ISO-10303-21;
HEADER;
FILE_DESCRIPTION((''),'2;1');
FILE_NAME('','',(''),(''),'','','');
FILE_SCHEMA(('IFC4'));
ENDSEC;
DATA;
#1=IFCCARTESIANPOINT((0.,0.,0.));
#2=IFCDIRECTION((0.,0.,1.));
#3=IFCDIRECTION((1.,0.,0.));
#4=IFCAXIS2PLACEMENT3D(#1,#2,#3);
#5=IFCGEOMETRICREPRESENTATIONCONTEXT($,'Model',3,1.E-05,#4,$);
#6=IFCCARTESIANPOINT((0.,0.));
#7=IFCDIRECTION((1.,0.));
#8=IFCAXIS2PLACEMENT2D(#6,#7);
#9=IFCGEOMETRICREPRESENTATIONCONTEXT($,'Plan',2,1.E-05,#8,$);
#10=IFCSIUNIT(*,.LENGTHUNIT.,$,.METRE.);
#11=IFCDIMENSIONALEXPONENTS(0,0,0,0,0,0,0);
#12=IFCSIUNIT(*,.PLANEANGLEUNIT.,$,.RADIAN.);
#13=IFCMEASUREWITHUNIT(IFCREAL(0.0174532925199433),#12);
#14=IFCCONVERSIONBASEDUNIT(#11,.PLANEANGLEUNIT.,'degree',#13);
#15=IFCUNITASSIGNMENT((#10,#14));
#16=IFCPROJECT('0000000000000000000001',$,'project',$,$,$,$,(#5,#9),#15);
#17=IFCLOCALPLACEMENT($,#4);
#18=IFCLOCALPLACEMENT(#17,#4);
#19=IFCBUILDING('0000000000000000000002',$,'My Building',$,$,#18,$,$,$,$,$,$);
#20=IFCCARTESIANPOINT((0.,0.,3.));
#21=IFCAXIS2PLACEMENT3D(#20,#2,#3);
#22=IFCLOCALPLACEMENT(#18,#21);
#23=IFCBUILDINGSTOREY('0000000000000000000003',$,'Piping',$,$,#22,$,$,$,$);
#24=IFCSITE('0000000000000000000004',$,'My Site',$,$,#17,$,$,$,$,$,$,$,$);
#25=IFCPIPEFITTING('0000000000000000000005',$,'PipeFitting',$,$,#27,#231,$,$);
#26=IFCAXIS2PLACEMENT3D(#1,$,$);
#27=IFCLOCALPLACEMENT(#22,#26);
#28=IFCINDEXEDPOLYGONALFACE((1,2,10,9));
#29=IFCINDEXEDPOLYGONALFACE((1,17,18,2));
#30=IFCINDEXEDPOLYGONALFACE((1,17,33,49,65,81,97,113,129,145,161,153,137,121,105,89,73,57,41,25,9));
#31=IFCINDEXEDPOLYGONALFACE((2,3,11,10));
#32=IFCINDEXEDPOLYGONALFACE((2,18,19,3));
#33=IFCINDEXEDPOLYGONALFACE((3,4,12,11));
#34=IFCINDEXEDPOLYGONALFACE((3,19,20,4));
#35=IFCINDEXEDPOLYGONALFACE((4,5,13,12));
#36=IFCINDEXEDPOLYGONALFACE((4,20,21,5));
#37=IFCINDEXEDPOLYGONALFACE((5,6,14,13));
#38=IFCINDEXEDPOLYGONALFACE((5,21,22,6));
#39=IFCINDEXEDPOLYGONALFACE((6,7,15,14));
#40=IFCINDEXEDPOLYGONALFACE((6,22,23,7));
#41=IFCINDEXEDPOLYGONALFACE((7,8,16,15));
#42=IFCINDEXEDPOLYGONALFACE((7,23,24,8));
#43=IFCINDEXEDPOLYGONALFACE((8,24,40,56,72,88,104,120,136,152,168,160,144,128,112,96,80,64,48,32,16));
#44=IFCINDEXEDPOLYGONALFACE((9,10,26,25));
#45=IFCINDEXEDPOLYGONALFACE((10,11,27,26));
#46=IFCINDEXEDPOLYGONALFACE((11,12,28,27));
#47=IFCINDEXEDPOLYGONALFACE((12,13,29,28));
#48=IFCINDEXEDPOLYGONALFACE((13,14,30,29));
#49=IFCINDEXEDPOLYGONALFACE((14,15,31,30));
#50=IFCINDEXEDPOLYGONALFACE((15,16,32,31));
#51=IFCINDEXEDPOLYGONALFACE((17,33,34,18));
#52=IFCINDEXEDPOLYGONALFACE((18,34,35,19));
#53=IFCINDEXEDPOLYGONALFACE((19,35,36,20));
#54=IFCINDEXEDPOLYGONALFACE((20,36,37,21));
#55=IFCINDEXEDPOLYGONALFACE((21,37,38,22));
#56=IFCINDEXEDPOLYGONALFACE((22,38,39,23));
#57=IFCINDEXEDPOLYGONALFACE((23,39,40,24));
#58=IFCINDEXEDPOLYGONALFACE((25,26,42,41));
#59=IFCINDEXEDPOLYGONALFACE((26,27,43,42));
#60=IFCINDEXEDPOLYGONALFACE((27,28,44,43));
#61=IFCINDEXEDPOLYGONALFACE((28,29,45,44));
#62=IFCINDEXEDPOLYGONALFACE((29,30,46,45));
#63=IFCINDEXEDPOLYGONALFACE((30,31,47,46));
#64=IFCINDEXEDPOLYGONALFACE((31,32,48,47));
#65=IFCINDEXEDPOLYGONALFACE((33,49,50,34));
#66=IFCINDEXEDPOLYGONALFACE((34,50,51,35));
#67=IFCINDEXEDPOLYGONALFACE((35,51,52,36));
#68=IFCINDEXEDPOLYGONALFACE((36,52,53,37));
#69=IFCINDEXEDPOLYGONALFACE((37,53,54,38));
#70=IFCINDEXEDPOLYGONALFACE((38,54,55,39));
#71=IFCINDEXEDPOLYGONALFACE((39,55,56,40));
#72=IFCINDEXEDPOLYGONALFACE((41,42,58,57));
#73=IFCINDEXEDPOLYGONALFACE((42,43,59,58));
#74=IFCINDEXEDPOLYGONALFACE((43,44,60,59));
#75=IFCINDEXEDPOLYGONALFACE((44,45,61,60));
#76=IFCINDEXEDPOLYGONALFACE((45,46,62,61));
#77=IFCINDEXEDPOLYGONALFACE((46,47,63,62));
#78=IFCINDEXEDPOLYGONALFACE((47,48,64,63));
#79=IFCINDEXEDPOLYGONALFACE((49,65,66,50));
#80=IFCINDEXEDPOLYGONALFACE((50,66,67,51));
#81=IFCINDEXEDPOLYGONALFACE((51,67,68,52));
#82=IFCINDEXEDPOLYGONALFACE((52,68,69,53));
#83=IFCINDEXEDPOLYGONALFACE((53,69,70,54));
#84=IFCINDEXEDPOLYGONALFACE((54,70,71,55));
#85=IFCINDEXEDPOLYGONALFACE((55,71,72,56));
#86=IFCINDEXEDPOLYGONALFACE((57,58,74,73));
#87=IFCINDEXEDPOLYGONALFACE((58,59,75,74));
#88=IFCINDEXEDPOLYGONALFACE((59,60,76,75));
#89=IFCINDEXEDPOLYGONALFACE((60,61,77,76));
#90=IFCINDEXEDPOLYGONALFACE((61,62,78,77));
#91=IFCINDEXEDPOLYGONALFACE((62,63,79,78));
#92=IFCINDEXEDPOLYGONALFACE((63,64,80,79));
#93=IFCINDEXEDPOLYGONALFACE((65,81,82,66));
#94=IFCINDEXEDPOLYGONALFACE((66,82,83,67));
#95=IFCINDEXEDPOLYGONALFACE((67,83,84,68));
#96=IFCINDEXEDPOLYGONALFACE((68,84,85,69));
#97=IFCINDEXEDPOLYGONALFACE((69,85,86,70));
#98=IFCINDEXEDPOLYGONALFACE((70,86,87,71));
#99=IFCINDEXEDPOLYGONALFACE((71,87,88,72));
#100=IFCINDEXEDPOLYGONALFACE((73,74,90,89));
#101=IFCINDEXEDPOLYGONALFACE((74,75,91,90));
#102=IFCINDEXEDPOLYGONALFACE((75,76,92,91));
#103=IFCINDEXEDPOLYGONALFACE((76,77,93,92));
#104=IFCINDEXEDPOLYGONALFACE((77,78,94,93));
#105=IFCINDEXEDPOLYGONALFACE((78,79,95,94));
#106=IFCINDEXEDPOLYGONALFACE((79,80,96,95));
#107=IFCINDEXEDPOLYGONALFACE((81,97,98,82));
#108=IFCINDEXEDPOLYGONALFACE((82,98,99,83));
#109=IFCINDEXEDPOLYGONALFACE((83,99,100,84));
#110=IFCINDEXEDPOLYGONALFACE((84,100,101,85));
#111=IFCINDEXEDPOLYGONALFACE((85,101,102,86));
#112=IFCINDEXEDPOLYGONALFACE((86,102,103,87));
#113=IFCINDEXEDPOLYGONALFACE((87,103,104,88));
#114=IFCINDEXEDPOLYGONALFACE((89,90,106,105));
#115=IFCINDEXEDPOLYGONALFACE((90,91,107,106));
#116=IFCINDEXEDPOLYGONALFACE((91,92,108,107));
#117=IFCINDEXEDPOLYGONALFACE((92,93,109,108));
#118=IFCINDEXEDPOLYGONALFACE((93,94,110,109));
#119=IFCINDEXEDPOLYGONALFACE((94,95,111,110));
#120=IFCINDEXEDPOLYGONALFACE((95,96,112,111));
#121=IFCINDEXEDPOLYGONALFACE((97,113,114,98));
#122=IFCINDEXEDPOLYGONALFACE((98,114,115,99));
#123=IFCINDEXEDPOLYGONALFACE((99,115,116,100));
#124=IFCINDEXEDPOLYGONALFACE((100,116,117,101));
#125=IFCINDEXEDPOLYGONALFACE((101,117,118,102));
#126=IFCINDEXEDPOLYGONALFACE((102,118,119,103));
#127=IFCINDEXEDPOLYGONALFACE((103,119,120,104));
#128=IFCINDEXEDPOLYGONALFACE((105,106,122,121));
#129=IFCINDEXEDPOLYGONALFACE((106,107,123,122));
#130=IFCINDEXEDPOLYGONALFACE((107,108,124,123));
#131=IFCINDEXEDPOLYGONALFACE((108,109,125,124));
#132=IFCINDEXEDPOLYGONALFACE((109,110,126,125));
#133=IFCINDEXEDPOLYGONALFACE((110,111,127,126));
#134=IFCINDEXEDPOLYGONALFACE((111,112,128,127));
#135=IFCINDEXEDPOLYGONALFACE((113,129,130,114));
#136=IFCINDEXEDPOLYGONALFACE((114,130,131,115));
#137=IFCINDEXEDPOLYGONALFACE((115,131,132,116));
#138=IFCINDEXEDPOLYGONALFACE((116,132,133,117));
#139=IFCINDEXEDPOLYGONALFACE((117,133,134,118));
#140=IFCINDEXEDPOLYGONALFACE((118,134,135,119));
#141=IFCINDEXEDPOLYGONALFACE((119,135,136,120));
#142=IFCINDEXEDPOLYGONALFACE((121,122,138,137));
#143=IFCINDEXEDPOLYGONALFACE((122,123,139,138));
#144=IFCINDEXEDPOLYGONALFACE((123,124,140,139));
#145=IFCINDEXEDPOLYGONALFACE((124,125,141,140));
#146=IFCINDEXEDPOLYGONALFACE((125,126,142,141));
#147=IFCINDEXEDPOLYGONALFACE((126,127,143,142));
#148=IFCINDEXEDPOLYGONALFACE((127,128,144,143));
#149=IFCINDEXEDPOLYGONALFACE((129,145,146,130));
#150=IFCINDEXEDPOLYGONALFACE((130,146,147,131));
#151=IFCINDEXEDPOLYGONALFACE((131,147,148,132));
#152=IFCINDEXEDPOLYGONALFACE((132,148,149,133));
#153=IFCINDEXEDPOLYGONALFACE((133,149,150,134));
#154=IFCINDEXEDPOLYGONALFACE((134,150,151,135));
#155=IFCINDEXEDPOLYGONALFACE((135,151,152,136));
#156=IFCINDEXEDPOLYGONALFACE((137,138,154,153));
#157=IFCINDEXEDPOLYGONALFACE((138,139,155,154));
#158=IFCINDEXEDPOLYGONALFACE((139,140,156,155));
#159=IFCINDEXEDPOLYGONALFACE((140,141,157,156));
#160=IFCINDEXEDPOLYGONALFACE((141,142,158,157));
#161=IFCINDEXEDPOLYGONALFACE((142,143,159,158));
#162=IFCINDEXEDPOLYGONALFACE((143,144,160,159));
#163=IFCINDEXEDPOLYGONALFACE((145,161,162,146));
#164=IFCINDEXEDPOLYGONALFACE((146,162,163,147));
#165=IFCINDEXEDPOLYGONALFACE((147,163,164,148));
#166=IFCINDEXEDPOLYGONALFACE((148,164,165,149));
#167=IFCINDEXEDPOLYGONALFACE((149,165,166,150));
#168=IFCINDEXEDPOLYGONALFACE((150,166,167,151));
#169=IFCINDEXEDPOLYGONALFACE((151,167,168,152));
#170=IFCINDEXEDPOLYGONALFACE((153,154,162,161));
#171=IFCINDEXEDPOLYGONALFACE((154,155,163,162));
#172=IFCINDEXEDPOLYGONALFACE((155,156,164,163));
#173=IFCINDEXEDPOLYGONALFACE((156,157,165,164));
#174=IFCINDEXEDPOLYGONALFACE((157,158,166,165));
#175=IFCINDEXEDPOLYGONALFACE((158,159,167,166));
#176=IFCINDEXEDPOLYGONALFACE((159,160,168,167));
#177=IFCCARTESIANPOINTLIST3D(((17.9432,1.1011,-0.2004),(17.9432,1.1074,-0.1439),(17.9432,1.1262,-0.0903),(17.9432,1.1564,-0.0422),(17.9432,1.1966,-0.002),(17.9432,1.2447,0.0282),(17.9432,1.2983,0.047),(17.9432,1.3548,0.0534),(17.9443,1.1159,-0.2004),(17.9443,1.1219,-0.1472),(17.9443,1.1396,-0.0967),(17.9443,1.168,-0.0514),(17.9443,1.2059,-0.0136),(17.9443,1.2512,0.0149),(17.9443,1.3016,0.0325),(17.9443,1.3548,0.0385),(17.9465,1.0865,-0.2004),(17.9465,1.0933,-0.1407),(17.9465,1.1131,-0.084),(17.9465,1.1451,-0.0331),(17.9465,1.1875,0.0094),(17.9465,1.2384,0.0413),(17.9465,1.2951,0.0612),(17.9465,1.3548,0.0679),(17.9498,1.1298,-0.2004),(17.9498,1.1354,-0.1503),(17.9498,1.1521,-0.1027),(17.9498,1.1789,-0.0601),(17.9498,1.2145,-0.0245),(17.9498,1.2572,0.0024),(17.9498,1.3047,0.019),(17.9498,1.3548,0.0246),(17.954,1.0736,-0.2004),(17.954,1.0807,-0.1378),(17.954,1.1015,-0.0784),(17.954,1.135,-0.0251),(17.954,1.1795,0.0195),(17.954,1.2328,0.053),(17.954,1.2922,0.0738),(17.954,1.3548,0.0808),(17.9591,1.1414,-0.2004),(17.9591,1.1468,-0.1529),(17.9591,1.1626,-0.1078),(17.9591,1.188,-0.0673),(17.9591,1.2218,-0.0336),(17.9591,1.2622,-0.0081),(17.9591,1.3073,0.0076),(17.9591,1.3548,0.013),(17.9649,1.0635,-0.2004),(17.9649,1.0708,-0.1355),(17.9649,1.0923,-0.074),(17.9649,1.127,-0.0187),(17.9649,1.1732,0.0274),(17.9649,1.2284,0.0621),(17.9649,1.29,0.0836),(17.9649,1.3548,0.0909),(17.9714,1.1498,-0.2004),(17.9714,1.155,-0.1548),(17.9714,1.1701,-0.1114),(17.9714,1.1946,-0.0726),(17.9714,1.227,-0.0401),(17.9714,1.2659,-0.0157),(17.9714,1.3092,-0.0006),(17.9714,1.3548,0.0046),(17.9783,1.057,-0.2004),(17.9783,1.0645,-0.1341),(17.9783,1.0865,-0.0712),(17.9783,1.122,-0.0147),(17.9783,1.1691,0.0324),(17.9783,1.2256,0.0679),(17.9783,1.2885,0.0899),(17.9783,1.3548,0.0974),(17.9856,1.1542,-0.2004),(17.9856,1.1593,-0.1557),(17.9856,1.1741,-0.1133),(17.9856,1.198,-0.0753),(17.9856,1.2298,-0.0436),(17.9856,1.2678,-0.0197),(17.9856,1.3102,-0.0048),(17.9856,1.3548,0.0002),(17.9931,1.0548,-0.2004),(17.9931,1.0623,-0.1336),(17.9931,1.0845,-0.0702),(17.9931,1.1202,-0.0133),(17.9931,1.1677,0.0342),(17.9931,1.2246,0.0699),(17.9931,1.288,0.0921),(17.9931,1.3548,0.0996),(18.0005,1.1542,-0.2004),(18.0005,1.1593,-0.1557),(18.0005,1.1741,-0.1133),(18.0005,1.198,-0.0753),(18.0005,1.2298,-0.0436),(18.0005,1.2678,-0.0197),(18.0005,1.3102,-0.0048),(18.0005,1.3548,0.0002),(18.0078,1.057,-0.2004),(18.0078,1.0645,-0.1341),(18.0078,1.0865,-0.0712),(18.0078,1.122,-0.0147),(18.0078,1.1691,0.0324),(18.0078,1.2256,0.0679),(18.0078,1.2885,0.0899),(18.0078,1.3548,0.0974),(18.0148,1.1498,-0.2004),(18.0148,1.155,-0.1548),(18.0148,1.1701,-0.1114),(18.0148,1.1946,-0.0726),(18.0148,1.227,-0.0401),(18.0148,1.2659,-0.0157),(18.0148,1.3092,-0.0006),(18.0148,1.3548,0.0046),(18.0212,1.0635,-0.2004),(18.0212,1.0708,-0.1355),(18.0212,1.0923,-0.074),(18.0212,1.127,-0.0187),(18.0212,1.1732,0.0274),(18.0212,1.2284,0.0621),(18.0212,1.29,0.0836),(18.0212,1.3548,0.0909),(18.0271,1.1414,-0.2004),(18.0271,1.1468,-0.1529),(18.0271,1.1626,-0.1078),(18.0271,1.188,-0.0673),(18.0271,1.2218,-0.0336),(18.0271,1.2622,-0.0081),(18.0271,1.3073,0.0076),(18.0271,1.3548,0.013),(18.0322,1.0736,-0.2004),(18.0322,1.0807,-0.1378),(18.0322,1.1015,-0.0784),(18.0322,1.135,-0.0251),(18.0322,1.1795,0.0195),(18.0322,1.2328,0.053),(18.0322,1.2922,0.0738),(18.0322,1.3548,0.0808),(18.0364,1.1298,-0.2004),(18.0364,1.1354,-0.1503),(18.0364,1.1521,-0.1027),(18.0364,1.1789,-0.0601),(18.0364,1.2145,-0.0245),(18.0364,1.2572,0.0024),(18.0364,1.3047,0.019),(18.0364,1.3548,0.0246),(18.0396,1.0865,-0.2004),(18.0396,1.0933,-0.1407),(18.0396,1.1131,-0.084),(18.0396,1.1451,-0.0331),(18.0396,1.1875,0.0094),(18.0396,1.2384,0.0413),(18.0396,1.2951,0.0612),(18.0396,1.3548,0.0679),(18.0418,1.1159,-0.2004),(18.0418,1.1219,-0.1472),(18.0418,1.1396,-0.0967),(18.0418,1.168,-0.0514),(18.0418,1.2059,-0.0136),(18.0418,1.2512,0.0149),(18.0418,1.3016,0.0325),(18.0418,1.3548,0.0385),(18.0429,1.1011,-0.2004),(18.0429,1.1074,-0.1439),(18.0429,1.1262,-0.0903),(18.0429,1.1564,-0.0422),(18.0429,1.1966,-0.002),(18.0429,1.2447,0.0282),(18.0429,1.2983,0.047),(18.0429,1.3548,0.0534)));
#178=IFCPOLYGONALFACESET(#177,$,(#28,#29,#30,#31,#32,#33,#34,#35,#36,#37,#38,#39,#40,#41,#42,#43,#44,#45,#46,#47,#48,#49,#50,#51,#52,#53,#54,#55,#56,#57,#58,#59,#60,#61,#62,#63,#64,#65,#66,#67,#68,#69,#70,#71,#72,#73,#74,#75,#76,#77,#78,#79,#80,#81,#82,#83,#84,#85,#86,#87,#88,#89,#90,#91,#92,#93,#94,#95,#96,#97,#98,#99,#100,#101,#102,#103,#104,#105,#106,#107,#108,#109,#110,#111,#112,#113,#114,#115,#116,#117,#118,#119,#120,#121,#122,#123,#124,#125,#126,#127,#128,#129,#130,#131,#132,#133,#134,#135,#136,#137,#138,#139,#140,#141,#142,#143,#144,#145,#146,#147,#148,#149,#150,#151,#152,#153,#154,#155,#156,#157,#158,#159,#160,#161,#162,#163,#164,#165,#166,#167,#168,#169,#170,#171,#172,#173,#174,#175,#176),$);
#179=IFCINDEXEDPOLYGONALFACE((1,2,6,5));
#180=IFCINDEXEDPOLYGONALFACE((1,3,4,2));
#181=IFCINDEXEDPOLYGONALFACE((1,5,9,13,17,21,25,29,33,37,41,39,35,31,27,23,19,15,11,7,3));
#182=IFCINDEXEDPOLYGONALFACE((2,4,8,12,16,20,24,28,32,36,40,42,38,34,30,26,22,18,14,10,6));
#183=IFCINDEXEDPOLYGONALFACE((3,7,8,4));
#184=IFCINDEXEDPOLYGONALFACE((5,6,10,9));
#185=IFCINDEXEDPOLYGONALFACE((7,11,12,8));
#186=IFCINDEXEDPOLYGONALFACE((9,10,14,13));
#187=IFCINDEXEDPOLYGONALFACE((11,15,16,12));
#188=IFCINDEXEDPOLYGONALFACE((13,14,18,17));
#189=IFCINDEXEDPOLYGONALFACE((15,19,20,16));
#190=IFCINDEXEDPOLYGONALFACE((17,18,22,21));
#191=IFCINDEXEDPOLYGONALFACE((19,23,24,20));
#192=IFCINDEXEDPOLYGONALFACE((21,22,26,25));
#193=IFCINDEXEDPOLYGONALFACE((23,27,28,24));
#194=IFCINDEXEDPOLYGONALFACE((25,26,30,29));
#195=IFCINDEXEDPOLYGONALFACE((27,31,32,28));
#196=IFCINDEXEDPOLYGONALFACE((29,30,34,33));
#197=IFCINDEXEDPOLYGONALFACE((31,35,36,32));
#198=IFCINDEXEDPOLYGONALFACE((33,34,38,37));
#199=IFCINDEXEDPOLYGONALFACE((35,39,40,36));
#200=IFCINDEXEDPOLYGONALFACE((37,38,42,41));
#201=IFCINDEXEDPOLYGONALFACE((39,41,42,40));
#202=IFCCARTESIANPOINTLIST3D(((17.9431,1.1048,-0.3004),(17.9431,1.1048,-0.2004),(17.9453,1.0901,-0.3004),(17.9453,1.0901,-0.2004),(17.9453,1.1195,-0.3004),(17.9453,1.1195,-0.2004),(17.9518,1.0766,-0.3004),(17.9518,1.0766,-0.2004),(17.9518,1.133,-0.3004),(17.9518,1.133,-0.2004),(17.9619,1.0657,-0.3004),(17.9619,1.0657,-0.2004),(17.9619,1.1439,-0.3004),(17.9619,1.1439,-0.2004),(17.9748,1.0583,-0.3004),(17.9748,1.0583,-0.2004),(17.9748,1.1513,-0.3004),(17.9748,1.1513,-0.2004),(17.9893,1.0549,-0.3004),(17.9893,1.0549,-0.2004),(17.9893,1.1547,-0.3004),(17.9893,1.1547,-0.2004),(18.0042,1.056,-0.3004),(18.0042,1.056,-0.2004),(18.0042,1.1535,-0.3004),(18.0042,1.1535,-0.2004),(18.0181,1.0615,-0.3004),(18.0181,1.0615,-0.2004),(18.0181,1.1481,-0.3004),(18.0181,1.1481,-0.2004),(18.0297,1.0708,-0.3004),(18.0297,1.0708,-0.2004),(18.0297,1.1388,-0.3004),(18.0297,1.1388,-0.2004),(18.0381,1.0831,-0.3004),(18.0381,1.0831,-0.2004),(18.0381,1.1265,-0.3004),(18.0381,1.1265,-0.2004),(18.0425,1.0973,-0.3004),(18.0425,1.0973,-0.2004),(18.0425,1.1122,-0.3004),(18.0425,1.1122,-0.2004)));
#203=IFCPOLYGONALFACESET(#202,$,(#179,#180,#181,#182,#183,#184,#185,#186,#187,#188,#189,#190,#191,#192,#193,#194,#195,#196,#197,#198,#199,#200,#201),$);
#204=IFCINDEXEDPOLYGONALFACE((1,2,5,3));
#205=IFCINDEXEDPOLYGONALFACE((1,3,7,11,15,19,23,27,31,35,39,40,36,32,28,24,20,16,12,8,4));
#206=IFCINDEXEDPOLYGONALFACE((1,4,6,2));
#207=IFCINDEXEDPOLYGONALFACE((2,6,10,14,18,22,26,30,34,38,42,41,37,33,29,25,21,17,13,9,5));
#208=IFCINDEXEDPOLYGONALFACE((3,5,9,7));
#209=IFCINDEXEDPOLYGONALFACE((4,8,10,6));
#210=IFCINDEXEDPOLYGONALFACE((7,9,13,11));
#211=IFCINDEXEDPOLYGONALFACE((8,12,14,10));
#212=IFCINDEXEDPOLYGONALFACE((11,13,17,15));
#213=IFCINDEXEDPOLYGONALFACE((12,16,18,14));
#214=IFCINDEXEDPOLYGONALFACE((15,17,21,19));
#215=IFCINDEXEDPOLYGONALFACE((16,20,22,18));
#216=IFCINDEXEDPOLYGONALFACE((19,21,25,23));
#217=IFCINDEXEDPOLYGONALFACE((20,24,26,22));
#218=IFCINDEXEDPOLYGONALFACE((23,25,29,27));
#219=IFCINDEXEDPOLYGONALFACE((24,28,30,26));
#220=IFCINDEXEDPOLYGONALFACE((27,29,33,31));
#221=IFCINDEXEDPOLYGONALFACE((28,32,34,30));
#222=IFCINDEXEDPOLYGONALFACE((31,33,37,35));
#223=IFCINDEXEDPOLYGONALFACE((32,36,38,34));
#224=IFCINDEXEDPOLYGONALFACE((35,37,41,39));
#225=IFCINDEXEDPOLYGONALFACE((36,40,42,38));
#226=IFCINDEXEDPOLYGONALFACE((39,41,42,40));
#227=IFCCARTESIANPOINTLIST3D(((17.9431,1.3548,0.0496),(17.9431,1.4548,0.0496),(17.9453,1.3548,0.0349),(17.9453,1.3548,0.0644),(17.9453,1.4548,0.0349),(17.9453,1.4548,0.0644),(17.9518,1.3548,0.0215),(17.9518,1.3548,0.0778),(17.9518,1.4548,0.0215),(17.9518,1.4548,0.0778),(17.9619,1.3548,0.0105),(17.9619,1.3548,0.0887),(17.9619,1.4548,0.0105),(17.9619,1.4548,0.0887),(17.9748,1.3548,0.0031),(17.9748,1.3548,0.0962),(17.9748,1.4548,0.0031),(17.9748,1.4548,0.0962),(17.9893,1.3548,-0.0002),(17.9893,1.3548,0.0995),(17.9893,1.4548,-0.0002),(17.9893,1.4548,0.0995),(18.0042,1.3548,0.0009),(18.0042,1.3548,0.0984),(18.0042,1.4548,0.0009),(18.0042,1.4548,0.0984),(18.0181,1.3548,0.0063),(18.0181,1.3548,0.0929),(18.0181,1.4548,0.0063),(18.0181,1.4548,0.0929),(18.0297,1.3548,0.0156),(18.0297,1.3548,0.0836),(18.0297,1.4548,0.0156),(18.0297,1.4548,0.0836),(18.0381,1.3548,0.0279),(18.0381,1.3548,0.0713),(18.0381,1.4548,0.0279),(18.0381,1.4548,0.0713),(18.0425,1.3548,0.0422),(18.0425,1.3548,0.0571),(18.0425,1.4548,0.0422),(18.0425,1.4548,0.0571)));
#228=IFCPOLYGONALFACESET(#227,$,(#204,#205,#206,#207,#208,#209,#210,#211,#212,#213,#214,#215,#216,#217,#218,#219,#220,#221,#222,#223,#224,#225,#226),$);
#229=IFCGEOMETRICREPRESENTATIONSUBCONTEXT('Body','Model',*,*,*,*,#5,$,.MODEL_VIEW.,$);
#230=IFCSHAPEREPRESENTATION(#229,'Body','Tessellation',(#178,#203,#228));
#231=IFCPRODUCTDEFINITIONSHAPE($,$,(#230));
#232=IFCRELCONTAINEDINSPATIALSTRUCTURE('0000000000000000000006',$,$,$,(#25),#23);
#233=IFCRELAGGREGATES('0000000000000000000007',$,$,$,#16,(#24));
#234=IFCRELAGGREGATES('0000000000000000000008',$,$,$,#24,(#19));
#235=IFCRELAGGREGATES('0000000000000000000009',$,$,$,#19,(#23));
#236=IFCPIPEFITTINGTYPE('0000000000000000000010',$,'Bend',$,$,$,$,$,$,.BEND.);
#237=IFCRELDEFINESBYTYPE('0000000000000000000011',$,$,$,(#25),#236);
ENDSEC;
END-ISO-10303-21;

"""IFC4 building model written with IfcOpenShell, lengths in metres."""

from ifc_helpers import new_model, entity, si_unit, converted_unit, frame, origin_with_axes, origin_2d_with_axis, place, context, subcontext, project, spatial, circle, extrude, source, transform, mapped, type_object, type_shapes, element, save


model = new_model("IFC4")

# Units and contexts
model_context = context("Model", 3, precision=1e-05, world=origin_with_axes())
plan_context = context("Plan", 2, precision=1e-05, world=origin_2d_with_axis())
body_context = subcontext(model_context, "Body", "Model", "MODEL_VIEW")
ifc_project = project(units=[si_unit("LENGTHUNIT", "METRE"), converted_unit("PLANEANGLEUNIT", "degree", entity("IfcReal", 0.0174532925199433), si_unit("PLANEANGLEUNIT", "RADIAN"), dimensions=[0, 0, 0, 0, 0, 0, 0])], contexts=[model_context, plan_context])

# Site, building, storey
site_placement = place(None, origin_with_axes())
site = spatial("IfcSite", under=ifc_project, at=site_placement, Name="My Site")
building_placement = place(site_placement, origin_with_axes())
building = spatial("IfcBuilding", under=site, at=building_placement, Name="My Building")
storey_placement = place(building_placement, frame((0.0, 0.0, 3.0), z_axis=(0.0, 0.0, 1.0), x_axis=(1.0, 0.0, 0.0)))
storey = spatial("IfcBuildingStorey", under=building, at=storey_placement, Name="Piping")

# Pipe fitting
pipe_fitting_type = type_object("IfcPipeFittingType", Name="Bend", PredefinedType="BEND")
shared_shape = source(origin_with_axes(), body_context, "Body", "SolidModel", [
    entity("IfcSweptDiskSolid", entity("IfcIndexedPolyCurve", entity("IfcCartesianPointList3D", [[0.0, 0.0, -0.1], [0.0, 0.0732, -0.2768], [0.0, 0.25, -0.35]]), [entity("IfcArcIndex", [1, 2, 3])]), 0.05),
    extrude(circle(Radius=0.05), origin_with_axes(), (0.0, 0.0, -1.0), 0.1),
    extrude(circle(Radius=0.05), frame((0.0, 0.25, -0.35), z_axis=(0.0, 1.0, 0.000007), x_axis=(1.0, 0.0, 0.0)), (0.0, 0.0, 1.0), 0.1),
])
type_shapes(pipe_fitting_type, [shared_shape])
for number, where, z_axis, x_axis, name in (
    (1, (17.9931, 1.1048, -0.3004), (0.0, 0.0, -1.0), (-1.0, 0.0, 0.0), "PipeFitting"),
):
    element("IfcPipeFitting", number, at=place(storey_placement, frame(where, z_axis=z_axis, x_axis=x_axis)), inside=storey, type_object=pipe_fitting_type, Name=name, context=body_context, shape_type="MappedRepresentation", body=[
        mapped(shared_shape, transform((0.0, 0.0, 0.0), x_axis=(1.0, 0.0, 0.0), y_axis=(0.0, 1.0, 0.0), z_axis=(0.0, 0.0, 1.0), scale=1.0)),
    ])

save(model, "model.ifc")
